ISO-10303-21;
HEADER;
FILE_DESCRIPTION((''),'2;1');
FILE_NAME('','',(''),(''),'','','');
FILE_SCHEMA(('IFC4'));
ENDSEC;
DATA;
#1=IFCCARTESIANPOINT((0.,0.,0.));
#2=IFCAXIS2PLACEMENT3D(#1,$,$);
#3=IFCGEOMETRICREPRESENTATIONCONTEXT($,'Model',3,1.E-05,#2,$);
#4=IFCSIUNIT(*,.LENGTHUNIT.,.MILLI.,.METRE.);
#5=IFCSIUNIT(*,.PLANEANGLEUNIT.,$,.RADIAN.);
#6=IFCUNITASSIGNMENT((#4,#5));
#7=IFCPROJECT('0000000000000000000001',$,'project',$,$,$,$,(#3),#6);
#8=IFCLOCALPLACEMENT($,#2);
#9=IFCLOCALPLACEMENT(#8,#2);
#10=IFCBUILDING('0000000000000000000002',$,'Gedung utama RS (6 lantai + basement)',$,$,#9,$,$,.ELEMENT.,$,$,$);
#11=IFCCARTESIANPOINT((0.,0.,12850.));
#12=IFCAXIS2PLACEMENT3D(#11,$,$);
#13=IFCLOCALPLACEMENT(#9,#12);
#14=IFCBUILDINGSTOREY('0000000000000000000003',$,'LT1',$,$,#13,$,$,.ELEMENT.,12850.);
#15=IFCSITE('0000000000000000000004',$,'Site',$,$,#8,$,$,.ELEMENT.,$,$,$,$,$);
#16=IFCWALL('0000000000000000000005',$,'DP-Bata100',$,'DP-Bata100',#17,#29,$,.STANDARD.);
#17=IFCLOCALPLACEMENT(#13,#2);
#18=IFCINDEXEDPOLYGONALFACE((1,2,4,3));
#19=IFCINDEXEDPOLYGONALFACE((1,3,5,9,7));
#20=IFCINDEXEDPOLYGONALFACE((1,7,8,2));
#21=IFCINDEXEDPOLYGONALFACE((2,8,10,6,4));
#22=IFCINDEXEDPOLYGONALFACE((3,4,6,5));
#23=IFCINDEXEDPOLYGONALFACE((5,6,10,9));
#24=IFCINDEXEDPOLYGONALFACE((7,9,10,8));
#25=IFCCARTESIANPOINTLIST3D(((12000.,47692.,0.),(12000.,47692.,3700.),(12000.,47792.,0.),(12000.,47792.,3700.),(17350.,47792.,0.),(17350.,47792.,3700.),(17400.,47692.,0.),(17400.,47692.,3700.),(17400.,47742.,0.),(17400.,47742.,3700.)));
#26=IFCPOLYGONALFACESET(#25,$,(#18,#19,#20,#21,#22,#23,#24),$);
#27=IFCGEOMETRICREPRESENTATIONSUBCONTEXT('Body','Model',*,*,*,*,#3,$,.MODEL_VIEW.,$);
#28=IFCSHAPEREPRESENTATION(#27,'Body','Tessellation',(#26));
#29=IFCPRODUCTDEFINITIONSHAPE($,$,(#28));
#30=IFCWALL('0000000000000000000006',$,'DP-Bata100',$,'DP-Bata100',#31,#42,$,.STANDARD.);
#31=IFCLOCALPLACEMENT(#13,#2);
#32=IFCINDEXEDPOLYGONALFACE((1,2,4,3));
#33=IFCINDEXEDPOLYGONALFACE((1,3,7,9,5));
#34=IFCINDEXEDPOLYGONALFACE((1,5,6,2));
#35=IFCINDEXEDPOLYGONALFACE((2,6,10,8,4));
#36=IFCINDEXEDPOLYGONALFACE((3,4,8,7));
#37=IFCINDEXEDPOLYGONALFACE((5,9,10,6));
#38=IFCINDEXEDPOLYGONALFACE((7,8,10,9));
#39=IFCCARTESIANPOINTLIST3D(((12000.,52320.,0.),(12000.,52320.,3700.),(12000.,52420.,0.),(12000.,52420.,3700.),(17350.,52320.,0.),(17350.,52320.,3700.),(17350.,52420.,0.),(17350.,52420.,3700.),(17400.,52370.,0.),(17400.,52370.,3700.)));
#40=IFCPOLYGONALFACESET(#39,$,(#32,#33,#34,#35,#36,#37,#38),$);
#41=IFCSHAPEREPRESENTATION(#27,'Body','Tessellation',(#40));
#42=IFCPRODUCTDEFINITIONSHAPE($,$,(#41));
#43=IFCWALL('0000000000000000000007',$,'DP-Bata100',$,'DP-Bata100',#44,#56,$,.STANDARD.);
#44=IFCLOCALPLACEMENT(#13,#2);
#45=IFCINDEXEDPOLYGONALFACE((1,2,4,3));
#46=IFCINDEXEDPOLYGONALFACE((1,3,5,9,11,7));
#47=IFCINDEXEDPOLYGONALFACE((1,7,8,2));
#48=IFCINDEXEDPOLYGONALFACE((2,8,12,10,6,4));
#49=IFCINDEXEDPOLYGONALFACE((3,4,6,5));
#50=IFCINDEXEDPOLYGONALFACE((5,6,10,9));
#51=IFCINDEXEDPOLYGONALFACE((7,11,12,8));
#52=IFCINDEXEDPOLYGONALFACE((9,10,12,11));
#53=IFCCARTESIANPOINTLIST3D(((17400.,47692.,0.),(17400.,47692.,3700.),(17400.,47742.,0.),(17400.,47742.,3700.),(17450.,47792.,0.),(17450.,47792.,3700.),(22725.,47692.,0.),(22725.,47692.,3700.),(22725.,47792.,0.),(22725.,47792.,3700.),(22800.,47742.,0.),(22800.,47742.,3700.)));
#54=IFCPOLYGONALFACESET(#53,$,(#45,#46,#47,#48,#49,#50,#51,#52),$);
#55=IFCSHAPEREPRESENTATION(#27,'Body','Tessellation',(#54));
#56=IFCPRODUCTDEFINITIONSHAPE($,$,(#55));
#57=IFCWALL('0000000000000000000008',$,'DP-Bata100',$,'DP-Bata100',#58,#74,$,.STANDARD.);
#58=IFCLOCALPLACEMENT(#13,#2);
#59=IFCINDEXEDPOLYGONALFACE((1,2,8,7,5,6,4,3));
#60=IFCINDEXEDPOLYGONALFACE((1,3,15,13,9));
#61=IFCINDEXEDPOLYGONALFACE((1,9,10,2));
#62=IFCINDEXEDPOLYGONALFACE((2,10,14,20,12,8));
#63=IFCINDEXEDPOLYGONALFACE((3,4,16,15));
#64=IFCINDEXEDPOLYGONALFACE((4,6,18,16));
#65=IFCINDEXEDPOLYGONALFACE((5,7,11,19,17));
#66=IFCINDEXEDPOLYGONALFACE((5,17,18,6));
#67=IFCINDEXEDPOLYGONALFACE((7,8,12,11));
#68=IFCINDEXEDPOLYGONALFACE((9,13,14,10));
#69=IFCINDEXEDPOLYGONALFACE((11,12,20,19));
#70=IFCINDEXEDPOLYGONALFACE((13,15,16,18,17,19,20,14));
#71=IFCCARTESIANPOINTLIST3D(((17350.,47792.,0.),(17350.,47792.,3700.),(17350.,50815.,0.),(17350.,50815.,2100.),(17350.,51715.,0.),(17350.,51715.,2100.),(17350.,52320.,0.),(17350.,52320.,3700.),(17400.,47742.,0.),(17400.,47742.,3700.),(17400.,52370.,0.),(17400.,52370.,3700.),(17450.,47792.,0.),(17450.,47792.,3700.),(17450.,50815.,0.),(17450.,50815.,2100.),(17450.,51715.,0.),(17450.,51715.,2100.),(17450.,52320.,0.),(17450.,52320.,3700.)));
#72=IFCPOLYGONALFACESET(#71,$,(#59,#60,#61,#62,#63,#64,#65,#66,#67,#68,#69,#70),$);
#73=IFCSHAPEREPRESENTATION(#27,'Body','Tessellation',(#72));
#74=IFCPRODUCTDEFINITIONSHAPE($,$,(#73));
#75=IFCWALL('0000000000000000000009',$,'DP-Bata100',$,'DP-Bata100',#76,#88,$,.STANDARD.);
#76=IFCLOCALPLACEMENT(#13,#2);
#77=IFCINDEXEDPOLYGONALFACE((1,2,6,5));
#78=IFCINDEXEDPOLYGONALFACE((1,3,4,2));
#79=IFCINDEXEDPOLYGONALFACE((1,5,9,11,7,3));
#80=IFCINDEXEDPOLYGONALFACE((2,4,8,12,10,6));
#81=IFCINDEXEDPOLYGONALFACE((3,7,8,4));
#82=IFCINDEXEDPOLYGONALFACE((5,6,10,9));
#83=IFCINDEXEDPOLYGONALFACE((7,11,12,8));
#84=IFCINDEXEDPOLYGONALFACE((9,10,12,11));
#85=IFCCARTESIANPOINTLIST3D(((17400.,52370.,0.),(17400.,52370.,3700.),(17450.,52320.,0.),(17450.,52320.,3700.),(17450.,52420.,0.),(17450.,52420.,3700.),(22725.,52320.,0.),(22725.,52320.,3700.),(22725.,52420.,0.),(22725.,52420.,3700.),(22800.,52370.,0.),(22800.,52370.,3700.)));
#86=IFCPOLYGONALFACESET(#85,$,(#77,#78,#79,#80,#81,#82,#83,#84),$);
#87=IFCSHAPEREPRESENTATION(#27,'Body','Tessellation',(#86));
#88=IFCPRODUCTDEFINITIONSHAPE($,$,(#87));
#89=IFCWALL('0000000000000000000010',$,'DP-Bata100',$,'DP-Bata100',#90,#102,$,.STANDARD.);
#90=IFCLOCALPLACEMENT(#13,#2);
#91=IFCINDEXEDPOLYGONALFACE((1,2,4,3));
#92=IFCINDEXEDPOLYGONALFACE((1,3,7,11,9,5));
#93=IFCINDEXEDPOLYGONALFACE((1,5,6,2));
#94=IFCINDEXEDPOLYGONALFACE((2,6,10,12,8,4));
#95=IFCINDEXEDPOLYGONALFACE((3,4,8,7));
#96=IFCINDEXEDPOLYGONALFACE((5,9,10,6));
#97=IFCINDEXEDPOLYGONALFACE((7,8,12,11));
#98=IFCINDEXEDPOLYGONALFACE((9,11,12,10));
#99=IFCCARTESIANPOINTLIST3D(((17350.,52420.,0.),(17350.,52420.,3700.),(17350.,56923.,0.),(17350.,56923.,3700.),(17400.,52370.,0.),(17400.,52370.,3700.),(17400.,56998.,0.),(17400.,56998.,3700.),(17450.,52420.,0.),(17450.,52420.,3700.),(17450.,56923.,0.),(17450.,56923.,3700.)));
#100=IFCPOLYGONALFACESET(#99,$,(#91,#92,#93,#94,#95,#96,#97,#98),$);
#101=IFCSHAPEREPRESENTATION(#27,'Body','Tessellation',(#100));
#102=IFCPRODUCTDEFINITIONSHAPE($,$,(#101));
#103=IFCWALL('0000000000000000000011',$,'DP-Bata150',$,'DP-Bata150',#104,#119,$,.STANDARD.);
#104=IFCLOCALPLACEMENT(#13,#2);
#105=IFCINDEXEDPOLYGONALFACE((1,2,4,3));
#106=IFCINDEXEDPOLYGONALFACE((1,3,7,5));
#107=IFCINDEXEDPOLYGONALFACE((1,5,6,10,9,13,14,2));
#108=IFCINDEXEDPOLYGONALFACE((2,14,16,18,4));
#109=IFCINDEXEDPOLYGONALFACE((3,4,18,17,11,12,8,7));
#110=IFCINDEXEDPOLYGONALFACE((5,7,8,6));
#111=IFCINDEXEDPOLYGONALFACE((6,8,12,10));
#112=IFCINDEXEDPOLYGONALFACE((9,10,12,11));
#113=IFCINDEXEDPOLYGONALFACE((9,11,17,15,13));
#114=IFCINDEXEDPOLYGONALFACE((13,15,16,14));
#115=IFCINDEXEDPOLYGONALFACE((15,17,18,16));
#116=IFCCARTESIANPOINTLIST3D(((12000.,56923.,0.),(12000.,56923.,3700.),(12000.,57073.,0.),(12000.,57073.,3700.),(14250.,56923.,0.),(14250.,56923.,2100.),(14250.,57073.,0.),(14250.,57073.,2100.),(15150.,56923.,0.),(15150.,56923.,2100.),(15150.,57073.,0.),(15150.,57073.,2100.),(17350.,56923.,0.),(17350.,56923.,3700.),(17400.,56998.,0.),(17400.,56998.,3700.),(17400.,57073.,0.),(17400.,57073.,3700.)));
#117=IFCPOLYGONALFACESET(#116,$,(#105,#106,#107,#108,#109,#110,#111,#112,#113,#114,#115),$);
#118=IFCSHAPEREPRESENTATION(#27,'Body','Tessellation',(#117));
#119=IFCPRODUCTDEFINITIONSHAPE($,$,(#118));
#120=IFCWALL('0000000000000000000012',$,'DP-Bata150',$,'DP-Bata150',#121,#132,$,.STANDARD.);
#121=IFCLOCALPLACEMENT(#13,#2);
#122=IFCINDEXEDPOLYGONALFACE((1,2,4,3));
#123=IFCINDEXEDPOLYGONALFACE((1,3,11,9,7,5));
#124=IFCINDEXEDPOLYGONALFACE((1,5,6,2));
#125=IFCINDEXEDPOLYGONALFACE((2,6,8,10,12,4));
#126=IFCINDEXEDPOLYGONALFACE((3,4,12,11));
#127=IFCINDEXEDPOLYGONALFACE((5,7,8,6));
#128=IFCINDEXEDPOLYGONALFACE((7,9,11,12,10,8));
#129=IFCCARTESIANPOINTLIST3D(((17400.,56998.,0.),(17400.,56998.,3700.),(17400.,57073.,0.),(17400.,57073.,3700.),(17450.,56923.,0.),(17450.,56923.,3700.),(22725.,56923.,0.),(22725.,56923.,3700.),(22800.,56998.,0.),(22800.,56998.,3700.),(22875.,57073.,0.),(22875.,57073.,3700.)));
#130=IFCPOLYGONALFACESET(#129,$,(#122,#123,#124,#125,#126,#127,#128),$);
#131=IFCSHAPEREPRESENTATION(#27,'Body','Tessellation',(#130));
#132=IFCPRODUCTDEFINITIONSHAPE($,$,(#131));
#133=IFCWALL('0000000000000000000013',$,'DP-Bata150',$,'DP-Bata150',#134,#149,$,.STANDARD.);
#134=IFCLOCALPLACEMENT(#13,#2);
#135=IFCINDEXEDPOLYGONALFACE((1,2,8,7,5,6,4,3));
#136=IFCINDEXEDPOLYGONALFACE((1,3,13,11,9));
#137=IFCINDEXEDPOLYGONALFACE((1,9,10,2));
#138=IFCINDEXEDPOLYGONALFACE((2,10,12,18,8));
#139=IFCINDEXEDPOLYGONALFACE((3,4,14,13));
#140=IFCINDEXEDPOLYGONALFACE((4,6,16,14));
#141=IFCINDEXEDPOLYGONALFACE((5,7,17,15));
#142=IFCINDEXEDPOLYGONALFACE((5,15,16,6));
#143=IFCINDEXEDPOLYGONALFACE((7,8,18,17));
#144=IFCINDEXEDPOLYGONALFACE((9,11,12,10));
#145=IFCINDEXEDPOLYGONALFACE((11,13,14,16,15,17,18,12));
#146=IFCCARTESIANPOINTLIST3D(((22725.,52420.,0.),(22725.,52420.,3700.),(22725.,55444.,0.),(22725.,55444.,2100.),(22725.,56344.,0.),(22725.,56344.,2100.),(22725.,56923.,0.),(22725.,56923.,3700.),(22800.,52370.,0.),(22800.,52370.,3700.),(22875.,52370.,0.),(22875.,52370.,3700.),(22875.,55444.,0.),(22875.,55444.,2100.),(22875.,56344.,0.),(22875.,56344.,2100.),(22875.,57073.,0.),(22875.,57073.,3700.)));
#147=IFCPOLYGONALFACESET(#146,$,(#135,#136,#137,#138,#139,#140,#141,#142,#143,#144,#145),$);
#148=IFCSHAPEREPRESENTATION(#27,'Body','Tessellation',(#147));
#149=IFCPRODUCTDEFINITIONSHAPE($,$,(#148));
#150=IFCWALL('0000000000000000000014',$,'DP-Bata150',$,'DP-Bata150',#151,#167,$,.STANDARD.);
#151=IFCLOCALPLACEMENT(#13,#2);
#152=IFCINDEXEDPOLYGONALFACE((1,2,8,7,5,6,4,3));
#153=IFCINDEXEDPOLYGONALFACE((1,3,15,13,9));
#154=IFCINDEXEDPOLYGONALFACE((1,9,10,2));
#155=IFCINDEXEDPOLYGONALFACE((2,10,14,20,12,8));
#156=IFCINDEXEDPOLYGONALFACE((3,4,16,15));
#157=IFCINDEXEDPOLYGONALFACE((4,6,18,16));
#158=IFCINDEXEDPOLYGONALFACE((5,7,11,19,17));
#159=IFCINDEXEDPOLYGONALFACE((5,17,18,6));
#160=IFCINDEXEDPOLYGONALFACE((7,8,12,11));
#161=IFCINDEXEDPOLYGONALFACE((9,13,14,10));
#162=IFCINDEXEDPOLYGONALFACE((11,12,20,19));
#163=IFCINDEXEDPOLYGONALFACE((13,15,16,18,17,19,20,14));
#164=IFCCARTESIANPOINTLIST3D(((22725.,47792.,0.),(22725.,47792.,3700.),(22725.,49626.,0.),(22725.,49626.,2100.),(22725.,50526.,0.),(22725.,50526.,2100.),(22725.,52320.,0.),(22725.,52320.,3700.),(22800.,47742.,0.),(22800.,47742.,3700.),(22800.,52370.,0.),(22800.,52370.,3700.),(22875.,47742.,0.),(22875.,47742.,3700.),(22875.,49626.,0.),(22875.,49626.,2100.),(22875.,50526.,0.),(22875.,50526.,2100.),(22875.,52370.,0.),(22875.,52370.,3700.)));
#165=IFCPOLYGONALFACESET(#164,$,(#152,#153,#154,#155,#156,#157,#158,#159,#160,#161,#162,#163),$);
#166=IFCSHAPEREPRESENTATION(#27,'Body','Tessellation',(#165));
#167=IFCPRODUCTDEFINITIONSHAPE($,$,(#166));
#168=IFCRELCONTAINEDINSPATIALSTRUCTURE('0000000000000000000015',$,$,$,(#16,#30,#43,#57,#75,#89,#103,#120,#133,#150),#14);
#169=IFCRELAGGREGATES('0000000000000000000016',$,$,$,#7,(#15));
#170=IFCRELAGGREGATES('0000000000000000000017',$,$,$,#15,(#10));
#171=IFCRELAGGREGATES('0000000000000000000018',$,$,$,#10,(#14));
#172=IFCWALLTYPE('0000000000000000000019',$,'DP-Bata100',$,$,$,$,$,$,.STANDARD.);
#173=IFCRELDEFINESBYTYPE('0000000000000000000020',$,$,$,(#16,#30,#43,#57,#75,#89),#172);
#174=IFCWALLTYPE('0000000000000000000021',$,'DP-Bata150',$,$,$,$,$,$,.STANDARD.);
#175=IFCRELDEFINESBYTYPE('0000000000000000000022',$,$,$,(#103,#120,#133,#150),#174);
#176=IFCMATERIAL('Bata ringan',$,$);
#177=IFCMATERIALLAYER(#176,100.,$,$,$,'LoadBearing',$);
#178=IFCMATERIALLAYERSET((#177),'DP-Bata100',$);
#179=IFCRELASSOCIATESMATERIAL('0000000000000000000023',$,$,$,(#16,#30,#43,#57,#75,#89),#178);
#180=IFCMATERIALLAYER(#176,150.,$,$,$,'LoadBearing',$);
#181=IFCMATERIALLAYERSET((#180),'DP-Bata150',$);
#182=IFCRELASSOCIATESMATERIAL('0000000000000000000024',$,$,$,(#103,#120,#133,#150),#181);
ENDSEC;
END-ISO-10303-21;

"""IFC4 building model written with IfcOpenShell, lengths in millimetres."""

from ifc_helpers import new_model, si_unit, frame, frame_2d, origin, place, context, subcontext, project, spatial, polyline, rectangle, outline, extrude, material, layer, layer_set, layer_usage, type_object, element, save


model = new_model("IFC4")

# Units and contexts
model_context = context("Model", 3, precision=1e-05, world=origin())
body_context = subcontext(model_context, "Body", "Model", "MODEL_VIEW")
ifc_project = project(units=[si_unit("LENGTHUNIT", "METRE", prefix="MILLI"), si_unit("PLANEANGLEUNIT", "RADIAN")], contexts=[model_context])

# Site, building, storey
site_placement = place(None, origin())
site = spatial("IfcSite", under=ifc_project, at=site_placement, Name="Site", CompositionType="ELEMENT")
building_placement = place(site_placement, origin())
building = spatial("IfcBuilding", under=site, at=building_placement, Name="Gedung utama RS (6 lantai + basement)", CompositionType="ELEMENT")
storey_placement = place(building_placement, frame((0.0, 0.0, 12850.0)))
storey = spatial("IfcBuildingStorey", under=building, at=storey_placement, Name="LT1", CompositionType="ELEMENT", Elevation=12850.0)

# Walls
ifc_material_1 = material(Name="Bata ringan")
ifc_layer_1 = layer(ifc_material_1, 100.0, Category="LoadBearing")
ifc_layer_set_1 = layer_set([ifc_layer_1], Name="DP-Bata100")
ifc_layer_usage_1 = layer_usage(ifc_layer_set_1, "AXIS2", "NEGATIVE", 50.0)
wall_type_1 = type_object("IfcWallType", Name="DP-Bata100", PredefinedType="STANDARD")
wall_1_placement = place(storey_placement, frame((12000.0, 47742.0, 0.0), z_axis=(0.0, 0.0, 1.0), x_axis=(1.0, 0.0, 0.0)))
element("IfcWall", 1, at=wall_1_placement, inside=storey, type_object=wall_type_1, material=ifc_layer_usage_1, Name="DP-Bata100", ObjectType="DP-Bata100", PredefinedType="STANDARD", context=body_context, shape_type="SweptSolid", body=[
    extrude(outline(polyline([(0.0, -50.0), (0.0, 50.0), (5350.0, 50.0), (5400.0, 0.0), (5400.0, -50.0), (0.0, -50.0)])), origin(), (0.0, 0.0, 1.0), 3700.0),
])
wall_2_placement = place(storey_placement, frame((17400.0, 52370.0, 0.0), z_axis=(0.0, 0.0, 1.0), x_axis=(-1.0, 0.0, 0.0)))
element("IfcWall", 2, at=wall_2_placement, inside=storey, type_object=wall_type_1, material=ifc_layer_usage_1, Name="DP-Bata100", ObjectType="DP-Bata100", PredefinedType="STANDARD", context=body_context, shape_type="SweptSolid", body=[
    extrude(outline(polyline([(50.0, -50.0), (0.0, 0.0), (50.0, 50.0), (5400.0, 50.0), (5400.0, -50.0), (50.0, -50.0)])), origin(), (0.0, 0.0, 1.0), 3700.0),
])
wall_3_placement = place(storey_placement, frame((17400.0, 47742.0, 0.0), z_axis=(0.0, 0.0, 1.0), x_axis=(1.0, 0.0, 0.0)))
element("IfcWall", 3, at=wall_3_placement, inside=storey, type_object=wall_type_1, material=ifc_layer_usage_1, Name="DP-Bata100", ObjectType="DP-Bata100", PredefinedType="STANDARD", context=body_context, shape_type="SweptSolid", body=[
    extrude(outline(polyline([(0.0, -50.0), (0.0, 0.0), (50.0, 50.0), (5325.0, 50.0), (5400.0, 0.0), (5325.0, -50.0), (0.0, -50.0)])), origin(), (0.0, 0.0, 1.0), 3700.0),
])

# Wall, opening
wall_4_placement = place(storey_placement, frame((17400.0, 52370.0, 0.0), z_axis=(0.0, 0.0, 1.0), x_axis=(0.0, -1.0, 0.0)))
wall_4 = element("IfcWall", 4, at=wall_4_placement, inside=storey, type_object=wall_type_1, material=ifc_layer_usage_1, Name="DP-Bata100", ObjectType="DP-Bata100", PredefinedType="STANDARD", context=body_context, shape_type="SweptSolid", body=[
    extrude(outline(polyline([(50.0, -50.0), (0.0, 0.0), (50.0, 50.0), (4578.0, 50.0), (4628.0, 0.0), (4578.0, -50.0), (50.0, -50.0)])), origin(), (0.0, 0.0, 1.0), 3700.0),
])
opening_1_placement = place(wall_4_placement, frame((655.0, 0.0, 0.0), z_axis=(0.0, 0.0, 1.0), x_axis=(1.0, 0.0, 0.0)))
element("IfcOpeningElement", 5, at=opening_1_placement, cuts=wall_4, PredefinedType="OPENING", context=body_context, shape_type="SweptSolid", body=[
    extrude(rectangle(XDim=900.0, YDim=120.0, at=frame_2d((450.0, 0.0))), origin(), (0.0, 0.0, 1.0), 2100.0),
])

# Walls
wall_5_placement = place(storey_placement, frame((22800.0, 52370.0, 0.0), z_axis=(0.0, 0.0, 1.0), x_axis=(-1.0, 0.0, 0.0)))
element("IfcWall", 6, at=wall_5_placement, inside=storey, type_object=wall_type_1, material=ifc_layer_usage_1, Name="DP-Bata100", ObjectType="DP-Bata100", PredefinedType="STANDARD", context=body_context, shape_type="SweptSolid", body=[
    extrude(outline(polyline([(75.0, -50.0), (0.0, 0.0), (75.0, 50.0), (5350.0, 50.0), (5400.0, 0.0), (5350.0, -50.0), (75.0, -50.0)])), origin(), (0.0, 0.0, 1.0), 3700.0),
])
wall_6_placement = place(storey_placement, frame((17400.0, 56998.0, 0.0), z_axis=(0.0, 0.0, 1.0), x_axis=(0.0, -1.0, 0.0)))
element("IfcWall", 7, at=wall_6_placement, inside=storey, type_object=wall_type_1, material=ifc_layer_usage_1, Name="DP-Bata100", ObjectType="DP-Bata100", PredefinedType="STANDARD", context=body_context, shape_type="SweptSolid", body=[
    extrude(outline(polyline([(75.0, -50.0), (0.0, 0.0), (75.0, 50.0), (4578.0, 50.0), (4628.0, 0.0), (4578.0, -50.0), (75.0, -50.0)])), origin(), (0.0, 0.0, 1.0), 3700.0),
])

# Wall, opening
ifc_layer_2 = layer(ifc_material_1, 150.0, Category="LoadBearing")
ifc_layer_set_2 = layer_set([ifc_layer_2], Name="DP-Bata150")
ifc_layer_usage_2 = layer_usage(ifc_layer_set_2, "AXIS2", "NEGATIVE", 75.0)
wall_type_2 = type_object("IfcWallType", Name="DP-Bata150", PredefinedType="STANDARD")
wall_7_placement = place(storey_placement, frame((12000.0, 56998.0, 0.0), z_axis=(0.0, 0.0, 1.0), x_axis=(1.0, 0.0, 0.0)))
wall_7 = element("IfcWall", 8, at=wall_7_placement, inside=storey, type_object=wall_type_2, material=ifc_layer_usage_2, Name="DP-Bata150", ObjectType="DP-Bata150", PredefinedType="STANDARD", context=body_context, shape_type="SweptSolid", body=[
    extrude(outline(polyline([(0.0, -75.0), (0.0, 75.0), (5400.0, 75.0), (5400.0, 0.0), (5350.0, -75.0), (0.0, -75.0)])), origin(), (0.0, 0.0, 1.0), 3700.0),
])
opening_2_placement = place(wall_7_placement, frame((2250.0, 0.0, 0.0), z_axis=(0.0, 0.0, 1.0), x_axis=(1.0, 0.0, 0.0)))
element("IfcOpeningElement", 9, at=opening_2_placement, cuts=wall_7, PredefinedType="OPENING", context=body_context, shape_type="SweptSolid", body=[
    extrude(rectangle(XDim=900.0, YDim=170.0, at=frame_2d((450.0, 0.0))), origin(), (0.0, 0.0, 1.0), 2100.0),
])

# Wall
wall_8_placement = place(storey_placement, frame((17400.0, 56998.0, 0.0), z_axis=(0.0, 0.0, 1.0), x_axis=(1.0, 0.0, 0.0)))
element("IfcWall", 10, at=wall_8_placement, inside=storey, type_object=wall_type_2, material=ifc_layer_usage_2, Name="DP-Bata150", ObjectType="DP-Bata150", PredefinedType="STANDARD", context=body_context, shape_type="SweptSolid", body=[
    extrude(outline(polyline([(50.0, -75.0), (0.0, 0.0), (0.0, 75.0), (5475.0, 75.0), (5400.0, 0.0), (5325.0, -75.0), (50.0, -75.0)])), origin(), (0.0, 0.0, 1.0), 3700.0),
])

# Walls, openings
wall_9_placement = place(storey_placement, frame((22800.0, 56998.0, 0.0), z_axis=(0.0, 0.0, 1.0), x_axis=(0.0, -1.0, 0.0)))
wall_9 = element("IfcWall", 11, at=wall_9_placement, inside=storey, type_object=wall_type_2, material=ifc_layer_usage_2, Name="DP-Bata150", ObjectType="DP-Bata150", PredefinedType="STANDARD", context=body_context, shape_type="SweptSolid", body=[
    extrude(outline(polyline([(75.0, -75.0), (0.0, 0.0), (-75.0, 75.0), (4628.0, 75.0), (4628.0, 0.0), (4578.0, -75.0), (75.0, -75.0)])), origin(), (0.0, 0.0, 1.0), 3700.0),
])
opening_3_placement = place(wall_9_placement, frame((654.0, 0.0, 0.0), z_axis=(0.0, 0.0, 1.0), x_axis=(1.0, 0.0, 0.0)))
element("IfcOpeningElement", 12, at=opening_3_placement, cuts=wall_9, PredefinedType="OPENING", context=body_context, shape_type="SweptSolid", body=[
    extrude(rectangle(XDim=900.0, YDim=170.0, at=frame_2d((450.0, 0.0))), origin(), (0.0, 0.0, 1.0), 2100.0),
])
wall_10_placement = place(storey_placement, frame((22800.0, 52370.0, 0.0), z_axis=(0.0, 0.0, 1.0), x_axis=(0.0, -1.0, 0.0)))
wall_10 = element("IfcWall", 13, at=wall_10_placement, inside=storey, type_object=wall_type_2, material=ifc_layer_usage_2, Name="DP-Bata150", ObjectType="DP-Bata150", PredefinedType="STANDARD", context=body_context, shape_type="SweptSolid", body=[
    extrude(outline(polyline([(50.0, -75.0), (0.0, 0.0), (0.0, 75.0), (4628.0, 75.0), (4628.0, 0.0), (4578.0, -75.0), (50.0, -75.0)])), origin(), (0.0, 0.0, 1.0), 3700.0),
])
opening_4_placement = place(wall_10_placement, frame((1844.0, 0.0, 0.0), z_axis=(0.0, 0.0, 1.0), x_axis=(1.0, 0.0, 0.0)))
element("IfcOpeningElement", 14, at=opening_4_placement, cuts=wall_10, PredefinedType="OPENING", context=body_context, shape_type="SweptSolid", body=[
    extrude(rectangle(XDim=900.0, YDim=170.0, at=frame_2d((450.0, 0.0))), origin(), (0.0, 0.0, 1.0), 2100.0),
])

save(model, "model.ifc")
